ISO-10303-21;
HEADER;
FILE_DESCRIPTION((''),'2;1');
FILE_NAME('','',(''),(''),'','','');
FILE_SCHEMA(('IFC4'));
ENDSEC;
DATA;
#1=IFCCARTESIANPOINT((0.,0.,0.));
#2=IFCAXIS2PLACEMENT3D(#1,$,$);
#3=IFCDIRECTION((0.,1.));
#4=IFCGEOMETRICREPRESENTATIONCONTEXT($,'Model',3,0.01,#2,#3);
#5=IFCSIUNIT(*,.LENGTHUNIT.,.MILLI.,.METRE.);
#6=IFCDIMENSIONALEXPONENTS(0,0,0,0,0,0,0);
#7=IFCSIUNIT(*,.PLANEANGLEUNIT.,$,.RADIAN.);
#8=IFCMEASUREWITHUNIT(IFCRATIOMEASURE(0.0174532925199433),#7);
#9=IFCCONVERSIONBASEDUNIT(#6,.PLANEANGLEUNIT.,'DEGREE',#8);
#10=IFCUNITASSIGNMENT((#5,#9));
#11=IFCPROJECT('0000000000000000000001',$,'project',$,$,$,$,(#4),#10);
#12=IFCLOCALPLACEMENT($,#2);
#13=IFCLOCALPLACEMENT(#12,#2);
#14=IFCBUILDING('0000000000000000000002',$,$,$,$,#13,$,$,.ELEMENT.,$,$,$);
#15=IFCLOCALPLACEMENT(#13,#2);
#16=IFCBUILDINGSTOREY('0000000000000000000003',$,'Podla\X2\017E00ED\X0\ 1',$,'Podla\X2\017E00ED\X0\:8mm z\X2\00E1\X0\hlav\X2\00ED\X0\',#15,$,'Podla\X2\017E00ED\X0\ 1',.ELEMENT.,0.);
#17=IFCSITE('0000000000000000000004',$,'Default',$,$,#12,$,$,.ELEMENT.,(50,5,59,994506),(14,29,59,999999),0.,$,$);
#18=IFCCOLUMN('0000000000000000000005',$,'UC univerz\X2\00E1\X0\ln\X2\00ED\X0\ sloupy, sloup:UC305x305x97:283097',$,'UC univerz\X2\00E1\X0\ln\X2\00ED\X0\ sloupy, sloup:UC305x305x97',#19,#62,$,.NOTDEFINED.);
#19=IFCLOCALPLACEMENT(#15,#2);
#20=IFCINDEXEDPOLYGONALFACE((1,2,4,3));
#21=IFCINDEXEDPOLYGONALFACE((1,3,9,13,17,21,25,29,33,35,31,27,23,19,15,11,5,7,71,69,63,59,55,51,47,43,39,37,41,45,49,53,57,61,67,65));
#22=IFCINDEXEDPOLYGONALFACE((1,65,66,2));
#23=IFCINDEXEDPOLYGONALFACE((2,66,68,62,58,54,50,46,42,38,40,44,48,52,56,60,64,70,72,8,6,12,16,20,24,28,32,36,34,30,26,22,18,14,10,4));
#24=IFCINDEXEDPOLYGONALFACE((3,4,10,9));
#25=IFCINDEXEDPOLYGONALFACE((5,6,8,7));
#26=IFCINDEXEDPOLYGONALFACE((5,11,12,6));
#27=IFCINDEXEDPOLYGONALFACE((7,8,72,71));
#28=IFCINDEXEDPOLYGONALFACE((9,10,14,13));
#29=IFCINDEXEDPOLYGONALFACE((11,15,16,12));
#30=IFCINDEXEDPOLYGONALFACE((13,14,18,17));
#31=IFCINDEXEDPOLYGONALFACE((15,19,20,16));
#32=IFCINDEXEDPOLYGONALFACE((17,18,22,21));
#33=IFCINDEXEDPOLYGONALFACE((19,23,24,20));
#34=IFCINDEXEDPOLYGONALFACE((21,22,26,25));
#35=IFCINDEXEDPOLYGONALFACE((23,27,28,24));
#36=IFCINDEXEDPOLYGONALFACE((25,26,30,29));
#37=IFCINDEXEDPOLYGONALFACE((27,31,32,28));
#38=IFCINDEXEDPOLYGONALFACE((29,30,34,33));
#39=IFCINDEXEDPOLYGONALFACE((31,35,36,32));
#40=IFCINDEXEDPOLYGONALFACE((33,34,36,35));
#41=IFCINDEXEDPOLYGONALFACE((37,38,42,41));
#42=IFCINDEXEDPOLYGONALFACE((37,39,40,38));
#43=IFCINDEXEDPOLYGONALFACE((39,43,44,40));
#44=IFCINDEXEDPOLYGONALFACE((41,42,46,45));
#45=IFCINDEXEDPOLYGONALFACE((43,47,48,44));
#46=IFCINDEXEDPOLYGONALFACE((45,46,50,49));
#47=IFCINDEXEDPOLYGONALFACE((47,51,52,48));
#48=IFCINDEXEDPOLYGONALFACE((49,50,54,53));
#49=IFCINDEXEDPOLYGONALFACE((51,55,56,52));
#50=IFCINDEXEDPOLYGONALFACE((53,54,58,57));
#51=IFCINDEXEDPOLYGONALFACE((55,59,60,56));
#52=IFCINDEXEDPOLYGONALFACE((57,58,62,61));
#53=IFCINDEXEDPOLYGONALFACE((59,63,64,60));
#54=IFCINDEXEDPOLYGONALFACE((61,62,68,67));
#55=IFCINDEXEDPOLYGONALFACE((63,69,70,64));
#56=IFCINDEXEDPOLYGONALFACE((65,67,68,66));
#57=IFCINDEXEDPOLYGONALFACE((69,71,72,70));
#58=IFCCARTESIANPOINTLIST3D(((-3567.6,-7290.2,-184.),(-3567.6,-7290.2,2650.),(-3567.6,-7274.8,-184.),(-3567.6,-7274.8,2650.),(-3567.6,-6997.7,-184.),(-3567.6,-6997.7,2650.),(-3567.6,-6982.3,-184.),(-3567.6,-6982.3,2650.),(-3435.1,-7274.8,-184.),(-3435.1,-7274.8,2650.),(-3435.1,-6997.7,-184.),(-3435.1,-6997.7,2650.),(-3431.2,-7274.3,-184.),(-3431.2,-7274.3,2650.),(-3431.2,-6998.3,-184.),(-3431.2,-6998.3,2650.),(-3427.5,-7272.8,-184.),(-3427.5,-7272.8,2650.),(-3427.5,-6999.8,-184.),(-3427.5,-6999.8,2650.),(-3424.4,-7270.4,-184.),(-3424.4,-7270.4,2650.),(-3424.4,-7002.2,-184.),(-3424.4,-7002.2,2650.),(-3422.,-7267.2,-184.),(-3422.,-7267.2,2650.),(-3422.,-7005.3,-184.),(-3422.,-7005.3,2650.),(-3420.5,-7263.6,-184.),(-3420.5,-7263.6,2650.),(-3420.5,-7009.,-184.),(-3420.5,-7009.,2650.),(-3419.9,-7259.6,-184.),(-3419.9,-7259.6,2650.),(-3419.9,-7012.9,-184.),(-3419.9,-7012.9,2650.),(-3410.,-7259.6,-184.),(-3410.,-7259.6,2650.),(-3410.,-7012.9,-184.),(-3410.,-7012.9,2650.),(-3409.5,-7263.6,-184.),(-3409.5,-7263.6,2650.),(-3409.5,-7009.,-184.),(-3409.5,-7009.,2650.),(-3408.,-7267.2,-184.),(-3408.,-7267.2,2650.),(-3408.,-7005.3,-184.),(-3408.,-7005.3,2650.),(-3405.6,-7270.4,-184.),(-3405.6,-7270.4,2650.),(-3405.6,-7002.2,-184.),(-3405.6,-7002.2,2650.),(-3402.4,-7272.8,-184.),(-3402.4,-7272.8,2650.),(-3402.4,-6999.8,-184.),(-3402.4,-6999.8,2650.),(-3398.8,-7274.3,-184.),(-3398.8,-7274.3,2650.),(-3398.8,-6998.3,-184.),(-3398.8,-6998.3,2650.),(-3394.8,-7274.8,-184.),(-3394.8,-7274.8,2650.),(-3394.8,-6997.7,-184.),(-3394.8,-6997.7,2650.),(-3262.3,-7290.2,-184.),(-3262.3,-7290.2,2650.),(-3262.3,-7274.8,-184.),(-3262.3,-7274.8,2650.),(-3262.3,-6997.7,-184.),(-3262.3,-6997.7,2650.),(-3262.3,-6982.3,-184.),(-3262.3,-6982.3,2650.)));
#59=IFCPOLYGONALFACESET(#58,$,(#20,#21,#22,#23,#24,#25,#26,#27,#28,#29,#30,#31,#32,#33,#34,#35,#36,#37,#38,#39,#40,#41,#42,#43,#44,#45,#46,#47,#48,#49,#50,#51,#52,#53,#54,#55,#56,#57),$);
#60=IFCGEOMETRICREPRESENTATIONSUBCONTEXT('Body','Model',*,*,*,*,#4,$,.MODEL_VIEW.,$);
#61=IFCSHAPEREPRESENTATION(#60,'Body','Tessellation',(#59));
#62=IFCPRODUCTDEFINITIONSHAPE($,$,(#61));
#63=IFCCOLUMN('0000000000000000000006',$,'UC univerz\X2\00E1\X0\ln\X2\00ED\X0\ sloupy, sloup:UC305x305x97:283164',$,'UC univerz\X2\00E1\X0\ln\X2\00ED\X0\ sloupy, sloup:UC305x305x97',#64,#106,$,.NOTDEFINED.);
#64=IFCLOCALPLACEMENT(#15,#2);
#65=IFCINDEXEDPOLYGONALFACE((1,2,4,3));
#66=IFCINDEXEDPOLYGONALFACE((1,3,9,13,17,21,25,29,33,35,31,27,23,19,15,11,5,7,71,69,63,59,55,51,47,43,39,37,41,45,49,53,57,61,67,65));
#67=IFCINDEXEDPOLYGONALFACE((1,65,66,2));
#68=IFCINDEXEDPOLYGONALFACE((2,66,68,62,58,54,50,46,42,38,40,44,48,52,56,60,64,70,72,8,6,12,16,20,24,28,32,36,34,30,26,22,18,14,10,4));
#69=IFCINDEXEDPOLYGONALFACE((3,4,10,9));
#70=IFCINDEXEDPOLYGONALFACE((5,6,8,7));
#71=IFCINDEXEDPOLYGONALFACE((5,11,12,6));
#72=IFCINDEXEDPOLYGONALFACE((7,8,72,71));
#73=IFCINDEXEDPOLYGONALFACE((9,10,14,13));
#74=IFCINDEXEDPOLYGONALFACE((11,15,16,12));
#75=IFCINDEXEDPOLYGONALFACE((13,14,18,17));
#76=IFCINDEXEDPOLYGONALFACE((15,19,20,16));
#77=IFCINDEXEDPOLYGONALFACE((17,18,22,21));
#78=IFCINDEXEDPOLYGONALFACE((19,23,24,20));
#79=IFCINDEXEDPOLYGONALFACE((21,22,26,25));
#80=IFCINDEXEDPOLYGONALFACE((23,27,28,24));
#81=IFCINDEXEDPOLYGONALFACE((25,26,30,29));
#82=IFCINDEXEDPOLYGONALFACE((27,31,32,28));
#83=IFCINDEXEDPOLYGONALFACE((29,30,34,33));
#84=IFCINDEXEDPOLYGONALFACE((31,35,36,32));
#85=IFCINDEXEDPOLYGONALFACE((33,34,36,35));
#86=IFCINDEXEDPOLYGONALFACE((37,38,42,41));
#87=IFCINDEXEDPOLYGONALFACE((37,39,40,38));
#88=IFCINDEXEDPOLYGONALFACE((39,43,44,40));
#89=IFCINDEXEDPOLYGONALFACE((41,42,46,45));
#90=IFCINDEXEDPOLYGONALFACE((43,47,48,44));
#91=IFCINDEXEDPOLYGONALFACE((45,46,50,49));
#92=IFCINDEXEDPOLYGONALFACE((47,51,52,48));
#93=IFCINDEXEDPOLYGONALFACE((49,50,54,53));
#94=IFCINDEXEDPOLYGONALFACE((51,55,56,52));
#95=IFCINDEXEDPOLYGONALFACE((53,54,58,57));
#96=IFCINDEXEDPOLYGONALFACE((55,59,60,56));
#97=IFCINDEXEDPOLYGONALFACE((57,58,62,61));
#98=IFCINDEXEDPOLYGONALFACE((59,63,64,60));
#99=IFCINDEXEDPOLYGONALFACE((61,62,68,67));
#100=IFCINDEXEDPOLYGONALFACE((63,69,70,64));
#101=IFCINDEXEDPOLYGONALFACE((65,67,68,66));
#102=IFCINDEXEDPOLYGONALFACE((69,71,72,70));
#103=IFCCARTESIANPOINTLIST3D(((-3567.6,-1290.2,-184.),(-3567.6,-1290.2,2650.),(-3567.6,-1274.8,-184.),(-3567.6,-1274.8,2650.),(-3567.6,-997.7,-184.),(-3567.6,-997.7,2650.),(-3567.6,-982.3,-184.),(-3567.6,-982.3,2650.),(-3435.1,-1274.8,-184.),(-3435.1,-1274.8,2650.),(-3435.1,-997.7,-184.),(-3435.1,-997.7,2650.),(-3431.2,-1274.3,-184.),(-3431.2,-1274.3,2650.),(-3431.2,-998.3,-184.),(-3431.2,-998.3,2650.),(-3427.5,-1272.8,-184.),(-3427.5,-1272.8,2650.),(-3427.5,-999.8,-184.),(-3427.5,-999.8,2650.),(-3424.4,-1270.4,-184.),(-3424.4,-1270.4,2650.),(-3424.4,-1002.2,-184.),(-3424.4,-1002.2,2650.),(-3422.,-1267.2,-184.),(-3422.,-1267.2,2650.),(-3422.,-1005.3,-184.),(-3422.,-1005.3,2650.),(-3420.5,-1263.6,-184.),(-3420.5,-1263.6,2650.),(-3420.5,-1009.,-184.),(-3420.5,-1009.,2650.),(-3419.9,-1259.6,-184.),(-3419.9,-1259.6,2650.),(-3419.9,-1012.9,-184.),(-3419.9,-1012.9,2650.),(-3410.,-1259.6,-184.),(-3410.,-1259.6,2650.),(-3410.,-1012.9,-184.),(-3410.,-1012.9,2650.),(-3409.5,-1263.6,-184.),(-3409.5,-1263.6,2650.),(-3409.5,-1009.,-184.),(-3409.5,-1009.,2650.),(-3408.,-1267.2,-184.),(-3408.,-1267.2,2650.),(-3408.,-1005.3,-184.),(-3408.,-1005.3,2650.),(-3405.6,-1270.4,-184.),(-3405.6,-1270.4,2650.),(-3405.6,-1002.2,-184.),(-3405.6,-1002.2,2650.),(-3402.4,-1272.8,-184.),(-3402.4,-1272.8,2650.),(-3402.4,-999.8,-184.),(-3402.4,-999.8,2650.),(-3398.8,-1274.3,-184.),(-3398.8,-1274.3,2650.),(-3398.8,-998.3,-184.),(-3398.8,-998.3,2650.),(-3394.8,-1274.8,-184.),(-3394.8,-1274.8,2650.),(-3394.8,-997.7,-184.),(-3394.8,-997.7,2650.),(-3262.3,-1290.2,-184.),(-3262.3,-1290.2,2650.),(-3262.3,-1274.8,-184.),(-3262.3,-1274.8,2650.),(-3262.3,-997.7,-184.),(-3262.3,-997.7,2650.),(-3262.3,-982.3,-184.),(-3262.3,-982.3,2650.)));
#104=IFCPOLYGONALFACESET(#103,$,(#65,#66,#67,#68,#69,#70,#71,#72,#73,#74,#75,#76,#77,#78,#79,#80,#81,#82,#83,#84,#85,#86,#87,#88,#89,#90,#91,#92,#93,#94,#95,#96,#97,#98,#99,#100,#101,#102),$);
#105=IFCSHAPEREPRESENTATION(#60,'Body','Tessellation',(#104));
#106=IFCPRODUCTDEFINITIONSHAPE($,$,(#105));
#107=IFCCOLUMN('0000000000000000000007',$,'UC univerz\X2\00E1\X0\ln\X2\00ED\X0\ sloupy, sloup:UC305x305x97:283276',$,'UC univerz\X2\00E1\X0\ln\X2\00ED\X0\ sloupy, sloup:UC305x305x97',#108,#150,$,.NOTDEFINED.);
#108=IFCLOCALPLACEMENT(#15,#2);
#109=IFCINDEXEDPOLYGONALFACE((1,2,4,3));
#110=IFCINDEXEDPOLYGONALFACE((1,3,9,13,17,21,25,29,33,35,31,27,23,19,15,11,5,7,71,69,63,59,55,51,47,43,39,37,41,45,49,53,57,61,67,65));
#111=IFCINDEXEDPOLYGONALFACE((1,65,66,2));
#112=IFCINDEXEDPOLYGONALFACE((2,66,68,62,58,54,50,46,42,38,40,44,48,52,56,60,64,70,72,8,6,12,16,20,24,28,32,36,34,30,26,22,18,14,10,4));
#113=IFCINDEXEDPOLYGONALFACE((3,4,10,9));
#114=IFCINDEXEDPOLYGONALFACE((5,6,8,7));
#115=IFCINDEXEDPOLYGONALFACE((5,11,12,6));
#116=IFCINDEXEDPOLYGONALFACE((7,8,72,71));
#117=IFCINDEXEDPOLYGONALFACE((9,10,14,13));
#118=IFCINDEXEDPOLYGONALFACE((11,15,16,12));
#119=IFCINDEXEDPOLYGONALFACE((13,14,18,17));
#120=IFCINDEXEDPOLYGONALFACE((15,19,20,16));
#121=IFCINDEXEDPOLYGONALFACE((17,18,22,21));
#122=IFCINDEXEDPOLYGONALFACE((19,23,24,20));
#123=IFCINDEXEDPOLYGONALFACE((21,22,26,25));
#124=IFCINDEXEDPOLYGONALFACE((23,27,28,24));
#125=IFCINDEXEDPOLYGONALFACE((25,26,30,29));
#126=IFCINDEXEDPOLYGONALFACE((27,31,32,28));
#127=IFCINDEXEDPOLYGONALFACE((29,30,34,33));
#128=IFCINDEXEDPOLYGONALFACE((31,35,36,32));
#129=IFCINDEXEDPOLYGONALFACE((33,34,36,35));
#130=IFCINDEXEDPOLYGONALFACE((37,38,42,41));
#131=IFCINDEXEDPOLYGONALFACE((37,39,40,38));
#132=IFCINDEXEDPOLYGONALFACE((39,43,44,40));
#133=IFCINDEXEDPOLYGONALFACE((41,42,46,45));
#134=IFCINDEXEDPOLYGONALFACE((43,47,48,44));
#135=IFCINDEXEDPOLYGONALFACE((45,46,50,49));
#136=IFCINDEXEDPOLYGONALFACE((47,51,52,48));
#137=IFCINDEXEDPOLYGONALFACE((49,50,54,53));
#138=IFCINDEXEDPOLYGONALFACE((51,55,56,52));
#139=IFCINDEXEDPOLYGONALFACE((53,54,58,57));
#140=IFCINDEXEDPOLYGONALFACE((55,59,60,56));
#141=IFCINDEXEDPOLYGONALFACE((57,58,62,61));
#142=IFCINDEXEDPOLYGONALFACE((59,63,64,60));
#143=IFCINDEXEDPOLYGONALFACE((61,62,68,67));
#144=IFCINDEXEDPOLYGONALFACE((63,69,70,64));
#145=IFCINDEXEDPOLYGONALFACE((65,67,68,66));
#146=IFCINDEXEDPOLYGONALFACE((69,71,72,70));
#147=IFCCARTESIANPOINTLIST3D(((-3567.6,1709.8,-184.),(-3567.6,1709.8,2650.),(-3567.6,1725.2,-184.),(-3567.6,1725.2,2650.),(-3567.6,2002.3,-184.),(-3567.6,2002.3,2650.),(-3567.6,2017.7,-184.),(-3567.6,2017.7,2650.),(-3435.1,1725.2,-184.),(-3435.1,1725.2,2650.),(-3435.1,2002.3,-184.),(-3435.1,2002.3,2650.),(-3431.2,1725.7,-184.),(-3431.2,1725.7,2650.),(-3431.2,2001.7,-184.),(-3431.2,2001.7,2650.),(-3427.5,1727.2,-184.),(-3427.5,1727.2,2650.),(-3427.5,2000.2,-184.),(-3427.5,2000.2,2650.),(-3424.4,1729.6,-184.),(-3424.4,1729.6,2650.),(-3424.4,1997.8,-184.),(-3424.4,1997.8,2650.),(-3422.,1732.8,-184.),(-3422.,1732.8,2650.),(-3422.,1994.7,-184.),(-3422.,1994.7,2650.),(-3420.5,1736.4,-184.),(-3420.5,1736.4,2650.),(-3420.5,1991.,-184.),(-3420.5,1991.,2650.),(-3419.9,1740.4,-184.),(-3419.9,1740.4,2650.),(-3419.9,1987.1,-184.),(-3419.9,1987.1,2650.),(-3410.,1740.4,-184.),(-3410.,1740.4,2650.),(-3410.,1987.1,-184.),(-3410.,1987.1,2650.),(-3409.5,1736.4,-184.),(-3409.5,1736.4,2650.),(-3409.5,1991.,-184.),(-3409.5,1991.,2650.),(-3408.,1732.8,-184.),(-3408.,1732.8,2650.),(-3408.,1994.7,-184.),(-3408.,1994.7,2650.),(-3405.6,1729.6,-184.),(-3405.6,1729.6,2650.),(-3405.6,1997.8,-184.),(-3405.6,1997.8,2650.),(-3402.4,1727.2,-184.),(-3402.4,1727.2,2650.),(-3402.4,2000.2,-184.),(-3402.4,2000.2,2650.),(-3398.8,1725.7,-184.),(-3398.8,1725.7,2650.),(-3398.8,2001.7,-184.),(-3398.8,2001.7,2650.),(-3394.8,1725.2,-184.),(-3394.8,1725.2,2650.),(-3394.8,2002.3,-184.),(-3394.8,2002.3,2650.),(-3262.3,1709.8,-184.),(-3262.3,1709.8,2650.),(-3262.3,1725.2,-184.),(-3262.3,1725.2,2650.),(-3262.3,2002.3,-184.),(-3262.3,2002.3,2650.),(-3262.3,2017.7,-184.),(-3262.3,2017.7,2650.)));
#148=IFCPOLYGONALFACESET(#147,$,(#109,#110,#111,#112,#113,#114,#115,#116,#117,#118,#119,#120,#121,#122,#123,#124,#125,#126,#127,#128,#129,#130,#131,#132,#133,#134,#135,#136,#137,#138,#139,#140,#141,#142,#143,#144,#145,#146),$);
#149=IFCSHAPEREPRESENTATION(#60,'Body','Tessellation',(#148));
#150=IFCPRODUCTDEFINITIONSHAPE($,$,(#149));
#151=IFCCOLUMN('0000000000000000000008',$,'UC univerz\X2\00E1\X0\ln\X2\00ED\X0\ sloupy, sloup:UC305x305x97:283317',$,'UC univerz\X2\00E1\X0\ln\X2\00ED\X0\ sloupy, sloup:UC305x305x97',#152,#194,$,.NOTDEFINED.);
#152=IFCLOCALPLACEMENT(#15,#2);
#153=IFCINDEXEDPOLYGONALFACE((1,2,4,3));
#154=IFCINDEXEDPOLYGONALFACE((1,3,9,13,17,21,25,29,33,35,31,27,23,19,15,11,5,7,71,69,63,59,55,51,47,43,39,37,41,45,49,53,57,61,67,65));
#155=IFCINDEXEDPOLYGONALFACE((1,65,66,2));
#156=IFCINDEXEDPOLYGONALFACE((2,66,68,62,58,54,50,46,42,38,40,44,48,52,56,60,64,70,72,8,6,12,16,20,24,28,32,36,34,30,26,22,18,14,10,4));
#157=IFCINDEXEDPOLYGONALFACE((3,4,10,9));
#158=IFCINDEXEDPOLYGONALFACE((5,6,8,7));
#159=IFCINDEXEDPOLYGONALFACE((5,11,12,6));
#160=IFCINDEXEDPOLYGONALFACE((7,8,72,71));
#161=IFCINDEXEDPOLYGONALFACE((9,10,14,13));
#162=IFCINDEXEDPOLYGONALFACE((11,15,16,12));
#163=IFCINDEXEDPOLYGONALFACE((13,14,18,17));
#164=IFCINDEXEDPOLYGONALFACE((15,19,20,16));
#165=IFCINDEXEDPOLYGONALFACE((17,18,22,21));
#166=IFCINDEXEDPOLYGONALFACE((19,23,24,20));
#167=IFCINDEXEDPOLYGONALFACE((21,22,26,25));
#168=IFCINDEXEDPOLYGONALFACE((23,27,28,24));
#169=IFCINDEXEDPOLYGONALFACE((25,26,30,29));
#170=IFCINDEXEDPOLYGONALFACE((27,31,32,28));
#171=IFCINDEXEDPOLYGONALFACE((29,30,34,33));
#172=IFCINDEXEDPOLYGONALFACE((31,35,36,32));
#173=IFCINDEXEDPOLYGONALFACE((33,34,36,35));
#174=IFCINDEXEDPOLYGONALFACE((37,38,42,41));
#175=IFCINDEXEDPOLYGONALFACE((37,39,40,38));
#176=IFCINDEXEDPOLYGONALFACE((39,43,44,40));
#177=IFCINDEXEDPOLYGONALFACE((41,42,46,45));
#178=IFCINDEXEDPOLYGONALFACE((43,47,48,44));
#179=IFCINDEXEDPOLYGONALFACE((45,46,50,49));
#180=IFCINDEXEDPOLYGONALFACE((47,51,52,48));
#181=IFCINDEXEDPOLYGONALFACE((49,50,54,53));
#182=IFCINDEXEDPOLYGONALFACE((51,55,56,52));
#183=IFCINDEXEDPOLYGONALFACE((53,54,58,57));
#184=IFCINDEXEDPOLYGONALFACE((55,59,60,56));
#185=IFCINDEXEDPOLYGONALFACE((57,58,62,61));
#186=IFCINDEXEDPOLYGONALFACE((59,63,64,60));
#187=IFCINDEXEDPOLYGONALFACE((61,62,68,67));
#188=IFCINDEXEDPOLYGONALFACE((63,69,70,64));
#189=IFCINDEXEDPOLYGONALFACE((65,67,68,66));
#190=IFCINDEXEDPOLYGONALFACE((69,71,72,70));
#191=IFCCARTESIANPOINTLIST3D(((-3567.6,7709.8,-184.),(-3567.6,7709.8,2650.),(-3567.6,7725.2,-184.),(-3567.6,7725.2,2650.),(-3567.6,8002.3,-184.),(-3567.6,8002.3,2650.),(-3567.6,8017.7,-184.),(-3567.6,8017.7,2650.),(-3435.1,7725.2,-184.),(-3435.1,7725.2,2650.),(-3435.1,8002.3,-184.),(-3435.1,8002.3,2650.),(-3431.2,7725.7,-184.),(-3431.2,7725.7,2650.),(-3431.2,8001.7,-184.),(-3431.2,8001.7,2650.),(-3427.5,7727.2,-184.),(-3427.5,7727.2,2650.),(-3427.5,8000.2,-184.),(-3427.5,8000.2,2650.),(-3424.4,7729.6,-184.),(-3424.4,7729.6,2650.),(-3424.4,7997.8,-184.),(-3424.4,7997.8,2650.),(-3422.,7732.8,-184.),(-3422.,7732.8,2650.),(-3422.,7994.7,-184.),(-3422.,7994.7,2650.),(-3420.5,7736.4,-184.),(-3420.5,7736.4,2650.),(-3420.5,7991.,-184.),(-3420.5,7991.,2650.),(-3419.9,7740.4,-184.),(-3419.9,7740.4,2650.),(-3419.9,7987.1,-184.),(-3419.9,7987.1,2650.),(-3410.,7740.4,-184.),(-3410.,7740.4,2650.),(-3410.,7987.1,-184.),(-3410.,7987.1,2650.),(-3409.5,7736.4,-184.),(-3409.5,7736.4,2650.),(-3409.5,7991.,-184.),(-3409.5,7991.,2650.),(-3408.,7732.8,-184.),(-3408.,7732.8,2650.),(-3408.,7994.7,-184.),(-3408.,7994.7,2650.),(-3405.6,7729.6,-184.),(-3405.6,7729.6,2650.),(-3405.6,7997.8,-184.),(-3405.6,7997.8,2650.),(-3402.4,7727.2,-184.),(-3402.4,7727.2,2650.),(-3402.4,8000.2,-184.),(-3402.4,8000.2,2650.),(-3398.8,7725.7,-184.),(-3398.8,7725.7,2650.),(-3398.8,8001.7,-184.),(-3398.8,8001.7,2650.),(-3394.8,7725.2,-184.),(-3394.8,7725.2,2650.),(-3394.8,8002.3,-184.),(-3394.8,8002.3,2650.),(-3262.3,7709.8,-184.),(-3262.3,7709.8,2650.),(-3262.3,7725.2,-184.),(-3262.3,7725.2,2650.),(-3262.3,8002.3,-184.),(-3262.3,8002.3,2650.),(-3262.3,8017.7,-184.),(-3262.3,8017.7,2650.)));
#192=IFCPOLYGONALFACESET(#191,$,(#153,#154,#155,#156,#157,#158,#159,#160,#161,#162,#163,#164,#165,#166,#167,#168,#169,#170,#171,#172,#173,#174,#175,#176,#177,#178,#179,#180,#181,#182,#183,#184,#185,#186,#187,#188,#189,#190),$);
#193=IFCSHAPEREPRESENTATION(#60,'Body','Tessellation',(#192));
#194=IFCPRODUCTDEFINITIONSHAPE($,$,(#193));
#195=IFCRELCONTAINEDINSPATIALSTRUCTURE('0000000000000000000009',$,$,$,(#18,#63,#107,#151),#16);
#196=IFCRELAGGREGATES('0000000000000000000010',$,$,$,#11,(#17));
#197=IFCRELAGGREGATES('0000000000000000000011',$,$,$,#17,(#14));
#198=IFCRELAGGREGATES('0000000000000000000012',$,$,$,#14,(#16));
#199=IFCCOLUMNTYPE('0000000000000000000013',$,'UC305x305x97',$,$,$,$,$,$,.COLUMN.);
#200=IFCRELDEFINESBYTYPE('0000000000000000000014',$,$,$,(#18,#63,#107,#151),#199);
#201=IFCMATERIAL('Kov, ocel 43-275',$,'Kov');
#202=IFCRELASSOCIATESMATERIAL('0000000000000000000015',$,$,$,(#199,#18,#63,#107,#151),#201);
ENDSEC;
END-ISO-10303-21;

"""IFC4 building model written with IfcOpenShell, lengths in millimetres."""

from ifc_helpers import new_model, entity, si_unit, converted_unit, direction, frame, frame_2d, origin, place, context, subcontext, project, spatial, i_section, extrude, source, transform, mapped, material, material_profile, profile_set, profile_usage, type_object, type_shapes, element, save


model = new_model("IFC4")

# Units and contexts
model_context = context("Model", 3, precision=0.01, world=origin(), true_north=direction((0.0, 1.0)))
body_context = subcontext(model_context, "Body", "Model", "MODEL_VIEW")
ifc_project = project(units=[si_unit("LENGTHUNIT", "METRE", prefix="MILLI"), converted_unit("PLANEANGLEUNIT", "DEGREE", entity("IfcRatioMeasure", 0.0174532925199433), si_unit("PLANEANGLEUNIT", "RADIAN"), dimensions=[0, 0, 0, 0, 0, 0, 0])], contexts=[model_context])

# Site, building, storey
site_placement = place(None, origin())
site = spatial("IfcSite", under=ifc_project, at=site_placement, Name="Default", CompositionType="ELEMENT", RefLatitude=(50, 5, 59, 994506), RefLongitude=(14, 29, 59, 999999), RefElevation=0.0)
building_placement = place(site_placement, origin())
building = spatial("IfcBuilding", under=site, at=building_placement, CompositionType="ELEMENT")
storey_placement = place(building_placement, origin())
storey = spatial("IfcBuildingStorey", under=building, at=storey_placement, Name="Podlaží 1", ObjectType="Podlaží:8mm záhlaví", LongName="Podlaží 1", CompositionType="ELEMENT", Elevation=0.0)

# Columns
ifc_material_1 = material(Name="Kov, ocel 43-275", Category="Kov")
ifc_material_profile = material_profile(ifc_material_1, i_section(OverallWidth=305.3, OverallDepth=307.9, WebThickness=9.9, FlangeThickness=15.4, FilletRadius=15.2, at=frame_2d((0.0, 0.0), x_axis=(0.0, 1.0))), Name="UC305x305x97")
ifc_profile_set = profile_set([ifc_material_profile], Name="UC305x305x97")
ifc_profile_usage_1 = profile_usage(ifc_profile_set)
column_type = type_object("IfcColumnType", Name="UC305x305x97", PredefinedType="COLUMN", material=ifc_profile_set)
shared_shape_1 = source(origin(), body_context, "Body", "SweptSolid", [
    extrude(i_section(OverallWidth=305.3, OverallDepth=307.9, WebThickness=9.9, FlangeThickness=15.4, FilletRadius=15.2, at=frame_2d((0.0, 0.0), x_axis=(0.0, 1.0))), frame((0.0, 0.0, -184.0), z_axis=(0.0, 0.0, 1.0), x_axis=(0.0, -1.0, 0.0)), (0.0, 0.0, 1.0), 2834.0),
])
type_shapes(column_type, [shared_shape_1])
column_1_placement = place(storey_placement, frame((-3415.0, -7136.3, 0.0)))
element("IfcColumn", 1, at=column_1_placement, inside=storey, type_object=column_type, material=ifc_profile_usage_1, Name="UC univerzální sloupy, sloup:UC305x305x97:283097", ObjectType="UC univerzální sloupy, sloup:UC305x305x97", PredefinedType="NOTDEFINED", context=body_context, shape_type="MappedRepresentation", body=[
    mapped(shared_shape_1, transform((0.0, 0.0, 0.0), scale=1.0)),
])
ifc_profile_usage_2 = profile_usage(ifc_profile_set)
column_2_placement = place(storey_placement, frame((-3415.0, -1136.3, 0.0)))
element("IfcColumn", 2, at=column_2_placement, inside=storey, type_object=column_type, material=ifc_profile_usage_2, Name="UC univerzální sloupy, sloup:UC305x305x97:283164", ObjectType="UC univerzální sloupy, sloup:UC305x305x97", PredefinedType="NOTDEFINED", context=body_context, shape_type="MappedRepresentation", body=[
    mapped(shared_shape_1, transform((0.0, 0.0, 0.0), scale=1.0)),
])
ifc_profile_usage_3 = profile_usage(ifc_profile_set)
column_3_placement = place(storey_placement, frame((-3415.0, 1863.7, 0.0)))
element("IfcColumn", 3, at=column_3_placement, inside=storey, type_object=column_type, material=ifc_profile_usage_3, Name="UC univerzální sloupy, sloup:UC305x305x97:283276", ObjectType="UC univerzální sloupy, sloup:UC305x305x97", PredefinedType="NOTDEFINED", context=body_context, shape_type="MappedRepresentation", body=[
    mapped(shared_shape_1, transform((0.0, 0.0, 0.0), scale=1.0)),
])
ifc_profile_usage_4 = profile_usage(ifc_profile_set)
column_4_placement = place(storey_placement, frame((-3415.0, 7863.7, 0.0)))
element("IfcColumn", 4, at=column_4_placement, inside=storey, type_object=column_type, material=ifc_profile_usage_4, Name="UC univerzální sloupy, sloup:UC305x305x97:283317", ObjectType="UC univerzální sloupy, sloup:UC305x305x97", PredefinedType="NOTDEFINED", context=body_context, shape_type="MappedRepresentation", body=[
    mapped(shared_shape_1, transform((0.0, 0.0, 0.0), scale=1.0)),
])

save(model, "model.ifc")
